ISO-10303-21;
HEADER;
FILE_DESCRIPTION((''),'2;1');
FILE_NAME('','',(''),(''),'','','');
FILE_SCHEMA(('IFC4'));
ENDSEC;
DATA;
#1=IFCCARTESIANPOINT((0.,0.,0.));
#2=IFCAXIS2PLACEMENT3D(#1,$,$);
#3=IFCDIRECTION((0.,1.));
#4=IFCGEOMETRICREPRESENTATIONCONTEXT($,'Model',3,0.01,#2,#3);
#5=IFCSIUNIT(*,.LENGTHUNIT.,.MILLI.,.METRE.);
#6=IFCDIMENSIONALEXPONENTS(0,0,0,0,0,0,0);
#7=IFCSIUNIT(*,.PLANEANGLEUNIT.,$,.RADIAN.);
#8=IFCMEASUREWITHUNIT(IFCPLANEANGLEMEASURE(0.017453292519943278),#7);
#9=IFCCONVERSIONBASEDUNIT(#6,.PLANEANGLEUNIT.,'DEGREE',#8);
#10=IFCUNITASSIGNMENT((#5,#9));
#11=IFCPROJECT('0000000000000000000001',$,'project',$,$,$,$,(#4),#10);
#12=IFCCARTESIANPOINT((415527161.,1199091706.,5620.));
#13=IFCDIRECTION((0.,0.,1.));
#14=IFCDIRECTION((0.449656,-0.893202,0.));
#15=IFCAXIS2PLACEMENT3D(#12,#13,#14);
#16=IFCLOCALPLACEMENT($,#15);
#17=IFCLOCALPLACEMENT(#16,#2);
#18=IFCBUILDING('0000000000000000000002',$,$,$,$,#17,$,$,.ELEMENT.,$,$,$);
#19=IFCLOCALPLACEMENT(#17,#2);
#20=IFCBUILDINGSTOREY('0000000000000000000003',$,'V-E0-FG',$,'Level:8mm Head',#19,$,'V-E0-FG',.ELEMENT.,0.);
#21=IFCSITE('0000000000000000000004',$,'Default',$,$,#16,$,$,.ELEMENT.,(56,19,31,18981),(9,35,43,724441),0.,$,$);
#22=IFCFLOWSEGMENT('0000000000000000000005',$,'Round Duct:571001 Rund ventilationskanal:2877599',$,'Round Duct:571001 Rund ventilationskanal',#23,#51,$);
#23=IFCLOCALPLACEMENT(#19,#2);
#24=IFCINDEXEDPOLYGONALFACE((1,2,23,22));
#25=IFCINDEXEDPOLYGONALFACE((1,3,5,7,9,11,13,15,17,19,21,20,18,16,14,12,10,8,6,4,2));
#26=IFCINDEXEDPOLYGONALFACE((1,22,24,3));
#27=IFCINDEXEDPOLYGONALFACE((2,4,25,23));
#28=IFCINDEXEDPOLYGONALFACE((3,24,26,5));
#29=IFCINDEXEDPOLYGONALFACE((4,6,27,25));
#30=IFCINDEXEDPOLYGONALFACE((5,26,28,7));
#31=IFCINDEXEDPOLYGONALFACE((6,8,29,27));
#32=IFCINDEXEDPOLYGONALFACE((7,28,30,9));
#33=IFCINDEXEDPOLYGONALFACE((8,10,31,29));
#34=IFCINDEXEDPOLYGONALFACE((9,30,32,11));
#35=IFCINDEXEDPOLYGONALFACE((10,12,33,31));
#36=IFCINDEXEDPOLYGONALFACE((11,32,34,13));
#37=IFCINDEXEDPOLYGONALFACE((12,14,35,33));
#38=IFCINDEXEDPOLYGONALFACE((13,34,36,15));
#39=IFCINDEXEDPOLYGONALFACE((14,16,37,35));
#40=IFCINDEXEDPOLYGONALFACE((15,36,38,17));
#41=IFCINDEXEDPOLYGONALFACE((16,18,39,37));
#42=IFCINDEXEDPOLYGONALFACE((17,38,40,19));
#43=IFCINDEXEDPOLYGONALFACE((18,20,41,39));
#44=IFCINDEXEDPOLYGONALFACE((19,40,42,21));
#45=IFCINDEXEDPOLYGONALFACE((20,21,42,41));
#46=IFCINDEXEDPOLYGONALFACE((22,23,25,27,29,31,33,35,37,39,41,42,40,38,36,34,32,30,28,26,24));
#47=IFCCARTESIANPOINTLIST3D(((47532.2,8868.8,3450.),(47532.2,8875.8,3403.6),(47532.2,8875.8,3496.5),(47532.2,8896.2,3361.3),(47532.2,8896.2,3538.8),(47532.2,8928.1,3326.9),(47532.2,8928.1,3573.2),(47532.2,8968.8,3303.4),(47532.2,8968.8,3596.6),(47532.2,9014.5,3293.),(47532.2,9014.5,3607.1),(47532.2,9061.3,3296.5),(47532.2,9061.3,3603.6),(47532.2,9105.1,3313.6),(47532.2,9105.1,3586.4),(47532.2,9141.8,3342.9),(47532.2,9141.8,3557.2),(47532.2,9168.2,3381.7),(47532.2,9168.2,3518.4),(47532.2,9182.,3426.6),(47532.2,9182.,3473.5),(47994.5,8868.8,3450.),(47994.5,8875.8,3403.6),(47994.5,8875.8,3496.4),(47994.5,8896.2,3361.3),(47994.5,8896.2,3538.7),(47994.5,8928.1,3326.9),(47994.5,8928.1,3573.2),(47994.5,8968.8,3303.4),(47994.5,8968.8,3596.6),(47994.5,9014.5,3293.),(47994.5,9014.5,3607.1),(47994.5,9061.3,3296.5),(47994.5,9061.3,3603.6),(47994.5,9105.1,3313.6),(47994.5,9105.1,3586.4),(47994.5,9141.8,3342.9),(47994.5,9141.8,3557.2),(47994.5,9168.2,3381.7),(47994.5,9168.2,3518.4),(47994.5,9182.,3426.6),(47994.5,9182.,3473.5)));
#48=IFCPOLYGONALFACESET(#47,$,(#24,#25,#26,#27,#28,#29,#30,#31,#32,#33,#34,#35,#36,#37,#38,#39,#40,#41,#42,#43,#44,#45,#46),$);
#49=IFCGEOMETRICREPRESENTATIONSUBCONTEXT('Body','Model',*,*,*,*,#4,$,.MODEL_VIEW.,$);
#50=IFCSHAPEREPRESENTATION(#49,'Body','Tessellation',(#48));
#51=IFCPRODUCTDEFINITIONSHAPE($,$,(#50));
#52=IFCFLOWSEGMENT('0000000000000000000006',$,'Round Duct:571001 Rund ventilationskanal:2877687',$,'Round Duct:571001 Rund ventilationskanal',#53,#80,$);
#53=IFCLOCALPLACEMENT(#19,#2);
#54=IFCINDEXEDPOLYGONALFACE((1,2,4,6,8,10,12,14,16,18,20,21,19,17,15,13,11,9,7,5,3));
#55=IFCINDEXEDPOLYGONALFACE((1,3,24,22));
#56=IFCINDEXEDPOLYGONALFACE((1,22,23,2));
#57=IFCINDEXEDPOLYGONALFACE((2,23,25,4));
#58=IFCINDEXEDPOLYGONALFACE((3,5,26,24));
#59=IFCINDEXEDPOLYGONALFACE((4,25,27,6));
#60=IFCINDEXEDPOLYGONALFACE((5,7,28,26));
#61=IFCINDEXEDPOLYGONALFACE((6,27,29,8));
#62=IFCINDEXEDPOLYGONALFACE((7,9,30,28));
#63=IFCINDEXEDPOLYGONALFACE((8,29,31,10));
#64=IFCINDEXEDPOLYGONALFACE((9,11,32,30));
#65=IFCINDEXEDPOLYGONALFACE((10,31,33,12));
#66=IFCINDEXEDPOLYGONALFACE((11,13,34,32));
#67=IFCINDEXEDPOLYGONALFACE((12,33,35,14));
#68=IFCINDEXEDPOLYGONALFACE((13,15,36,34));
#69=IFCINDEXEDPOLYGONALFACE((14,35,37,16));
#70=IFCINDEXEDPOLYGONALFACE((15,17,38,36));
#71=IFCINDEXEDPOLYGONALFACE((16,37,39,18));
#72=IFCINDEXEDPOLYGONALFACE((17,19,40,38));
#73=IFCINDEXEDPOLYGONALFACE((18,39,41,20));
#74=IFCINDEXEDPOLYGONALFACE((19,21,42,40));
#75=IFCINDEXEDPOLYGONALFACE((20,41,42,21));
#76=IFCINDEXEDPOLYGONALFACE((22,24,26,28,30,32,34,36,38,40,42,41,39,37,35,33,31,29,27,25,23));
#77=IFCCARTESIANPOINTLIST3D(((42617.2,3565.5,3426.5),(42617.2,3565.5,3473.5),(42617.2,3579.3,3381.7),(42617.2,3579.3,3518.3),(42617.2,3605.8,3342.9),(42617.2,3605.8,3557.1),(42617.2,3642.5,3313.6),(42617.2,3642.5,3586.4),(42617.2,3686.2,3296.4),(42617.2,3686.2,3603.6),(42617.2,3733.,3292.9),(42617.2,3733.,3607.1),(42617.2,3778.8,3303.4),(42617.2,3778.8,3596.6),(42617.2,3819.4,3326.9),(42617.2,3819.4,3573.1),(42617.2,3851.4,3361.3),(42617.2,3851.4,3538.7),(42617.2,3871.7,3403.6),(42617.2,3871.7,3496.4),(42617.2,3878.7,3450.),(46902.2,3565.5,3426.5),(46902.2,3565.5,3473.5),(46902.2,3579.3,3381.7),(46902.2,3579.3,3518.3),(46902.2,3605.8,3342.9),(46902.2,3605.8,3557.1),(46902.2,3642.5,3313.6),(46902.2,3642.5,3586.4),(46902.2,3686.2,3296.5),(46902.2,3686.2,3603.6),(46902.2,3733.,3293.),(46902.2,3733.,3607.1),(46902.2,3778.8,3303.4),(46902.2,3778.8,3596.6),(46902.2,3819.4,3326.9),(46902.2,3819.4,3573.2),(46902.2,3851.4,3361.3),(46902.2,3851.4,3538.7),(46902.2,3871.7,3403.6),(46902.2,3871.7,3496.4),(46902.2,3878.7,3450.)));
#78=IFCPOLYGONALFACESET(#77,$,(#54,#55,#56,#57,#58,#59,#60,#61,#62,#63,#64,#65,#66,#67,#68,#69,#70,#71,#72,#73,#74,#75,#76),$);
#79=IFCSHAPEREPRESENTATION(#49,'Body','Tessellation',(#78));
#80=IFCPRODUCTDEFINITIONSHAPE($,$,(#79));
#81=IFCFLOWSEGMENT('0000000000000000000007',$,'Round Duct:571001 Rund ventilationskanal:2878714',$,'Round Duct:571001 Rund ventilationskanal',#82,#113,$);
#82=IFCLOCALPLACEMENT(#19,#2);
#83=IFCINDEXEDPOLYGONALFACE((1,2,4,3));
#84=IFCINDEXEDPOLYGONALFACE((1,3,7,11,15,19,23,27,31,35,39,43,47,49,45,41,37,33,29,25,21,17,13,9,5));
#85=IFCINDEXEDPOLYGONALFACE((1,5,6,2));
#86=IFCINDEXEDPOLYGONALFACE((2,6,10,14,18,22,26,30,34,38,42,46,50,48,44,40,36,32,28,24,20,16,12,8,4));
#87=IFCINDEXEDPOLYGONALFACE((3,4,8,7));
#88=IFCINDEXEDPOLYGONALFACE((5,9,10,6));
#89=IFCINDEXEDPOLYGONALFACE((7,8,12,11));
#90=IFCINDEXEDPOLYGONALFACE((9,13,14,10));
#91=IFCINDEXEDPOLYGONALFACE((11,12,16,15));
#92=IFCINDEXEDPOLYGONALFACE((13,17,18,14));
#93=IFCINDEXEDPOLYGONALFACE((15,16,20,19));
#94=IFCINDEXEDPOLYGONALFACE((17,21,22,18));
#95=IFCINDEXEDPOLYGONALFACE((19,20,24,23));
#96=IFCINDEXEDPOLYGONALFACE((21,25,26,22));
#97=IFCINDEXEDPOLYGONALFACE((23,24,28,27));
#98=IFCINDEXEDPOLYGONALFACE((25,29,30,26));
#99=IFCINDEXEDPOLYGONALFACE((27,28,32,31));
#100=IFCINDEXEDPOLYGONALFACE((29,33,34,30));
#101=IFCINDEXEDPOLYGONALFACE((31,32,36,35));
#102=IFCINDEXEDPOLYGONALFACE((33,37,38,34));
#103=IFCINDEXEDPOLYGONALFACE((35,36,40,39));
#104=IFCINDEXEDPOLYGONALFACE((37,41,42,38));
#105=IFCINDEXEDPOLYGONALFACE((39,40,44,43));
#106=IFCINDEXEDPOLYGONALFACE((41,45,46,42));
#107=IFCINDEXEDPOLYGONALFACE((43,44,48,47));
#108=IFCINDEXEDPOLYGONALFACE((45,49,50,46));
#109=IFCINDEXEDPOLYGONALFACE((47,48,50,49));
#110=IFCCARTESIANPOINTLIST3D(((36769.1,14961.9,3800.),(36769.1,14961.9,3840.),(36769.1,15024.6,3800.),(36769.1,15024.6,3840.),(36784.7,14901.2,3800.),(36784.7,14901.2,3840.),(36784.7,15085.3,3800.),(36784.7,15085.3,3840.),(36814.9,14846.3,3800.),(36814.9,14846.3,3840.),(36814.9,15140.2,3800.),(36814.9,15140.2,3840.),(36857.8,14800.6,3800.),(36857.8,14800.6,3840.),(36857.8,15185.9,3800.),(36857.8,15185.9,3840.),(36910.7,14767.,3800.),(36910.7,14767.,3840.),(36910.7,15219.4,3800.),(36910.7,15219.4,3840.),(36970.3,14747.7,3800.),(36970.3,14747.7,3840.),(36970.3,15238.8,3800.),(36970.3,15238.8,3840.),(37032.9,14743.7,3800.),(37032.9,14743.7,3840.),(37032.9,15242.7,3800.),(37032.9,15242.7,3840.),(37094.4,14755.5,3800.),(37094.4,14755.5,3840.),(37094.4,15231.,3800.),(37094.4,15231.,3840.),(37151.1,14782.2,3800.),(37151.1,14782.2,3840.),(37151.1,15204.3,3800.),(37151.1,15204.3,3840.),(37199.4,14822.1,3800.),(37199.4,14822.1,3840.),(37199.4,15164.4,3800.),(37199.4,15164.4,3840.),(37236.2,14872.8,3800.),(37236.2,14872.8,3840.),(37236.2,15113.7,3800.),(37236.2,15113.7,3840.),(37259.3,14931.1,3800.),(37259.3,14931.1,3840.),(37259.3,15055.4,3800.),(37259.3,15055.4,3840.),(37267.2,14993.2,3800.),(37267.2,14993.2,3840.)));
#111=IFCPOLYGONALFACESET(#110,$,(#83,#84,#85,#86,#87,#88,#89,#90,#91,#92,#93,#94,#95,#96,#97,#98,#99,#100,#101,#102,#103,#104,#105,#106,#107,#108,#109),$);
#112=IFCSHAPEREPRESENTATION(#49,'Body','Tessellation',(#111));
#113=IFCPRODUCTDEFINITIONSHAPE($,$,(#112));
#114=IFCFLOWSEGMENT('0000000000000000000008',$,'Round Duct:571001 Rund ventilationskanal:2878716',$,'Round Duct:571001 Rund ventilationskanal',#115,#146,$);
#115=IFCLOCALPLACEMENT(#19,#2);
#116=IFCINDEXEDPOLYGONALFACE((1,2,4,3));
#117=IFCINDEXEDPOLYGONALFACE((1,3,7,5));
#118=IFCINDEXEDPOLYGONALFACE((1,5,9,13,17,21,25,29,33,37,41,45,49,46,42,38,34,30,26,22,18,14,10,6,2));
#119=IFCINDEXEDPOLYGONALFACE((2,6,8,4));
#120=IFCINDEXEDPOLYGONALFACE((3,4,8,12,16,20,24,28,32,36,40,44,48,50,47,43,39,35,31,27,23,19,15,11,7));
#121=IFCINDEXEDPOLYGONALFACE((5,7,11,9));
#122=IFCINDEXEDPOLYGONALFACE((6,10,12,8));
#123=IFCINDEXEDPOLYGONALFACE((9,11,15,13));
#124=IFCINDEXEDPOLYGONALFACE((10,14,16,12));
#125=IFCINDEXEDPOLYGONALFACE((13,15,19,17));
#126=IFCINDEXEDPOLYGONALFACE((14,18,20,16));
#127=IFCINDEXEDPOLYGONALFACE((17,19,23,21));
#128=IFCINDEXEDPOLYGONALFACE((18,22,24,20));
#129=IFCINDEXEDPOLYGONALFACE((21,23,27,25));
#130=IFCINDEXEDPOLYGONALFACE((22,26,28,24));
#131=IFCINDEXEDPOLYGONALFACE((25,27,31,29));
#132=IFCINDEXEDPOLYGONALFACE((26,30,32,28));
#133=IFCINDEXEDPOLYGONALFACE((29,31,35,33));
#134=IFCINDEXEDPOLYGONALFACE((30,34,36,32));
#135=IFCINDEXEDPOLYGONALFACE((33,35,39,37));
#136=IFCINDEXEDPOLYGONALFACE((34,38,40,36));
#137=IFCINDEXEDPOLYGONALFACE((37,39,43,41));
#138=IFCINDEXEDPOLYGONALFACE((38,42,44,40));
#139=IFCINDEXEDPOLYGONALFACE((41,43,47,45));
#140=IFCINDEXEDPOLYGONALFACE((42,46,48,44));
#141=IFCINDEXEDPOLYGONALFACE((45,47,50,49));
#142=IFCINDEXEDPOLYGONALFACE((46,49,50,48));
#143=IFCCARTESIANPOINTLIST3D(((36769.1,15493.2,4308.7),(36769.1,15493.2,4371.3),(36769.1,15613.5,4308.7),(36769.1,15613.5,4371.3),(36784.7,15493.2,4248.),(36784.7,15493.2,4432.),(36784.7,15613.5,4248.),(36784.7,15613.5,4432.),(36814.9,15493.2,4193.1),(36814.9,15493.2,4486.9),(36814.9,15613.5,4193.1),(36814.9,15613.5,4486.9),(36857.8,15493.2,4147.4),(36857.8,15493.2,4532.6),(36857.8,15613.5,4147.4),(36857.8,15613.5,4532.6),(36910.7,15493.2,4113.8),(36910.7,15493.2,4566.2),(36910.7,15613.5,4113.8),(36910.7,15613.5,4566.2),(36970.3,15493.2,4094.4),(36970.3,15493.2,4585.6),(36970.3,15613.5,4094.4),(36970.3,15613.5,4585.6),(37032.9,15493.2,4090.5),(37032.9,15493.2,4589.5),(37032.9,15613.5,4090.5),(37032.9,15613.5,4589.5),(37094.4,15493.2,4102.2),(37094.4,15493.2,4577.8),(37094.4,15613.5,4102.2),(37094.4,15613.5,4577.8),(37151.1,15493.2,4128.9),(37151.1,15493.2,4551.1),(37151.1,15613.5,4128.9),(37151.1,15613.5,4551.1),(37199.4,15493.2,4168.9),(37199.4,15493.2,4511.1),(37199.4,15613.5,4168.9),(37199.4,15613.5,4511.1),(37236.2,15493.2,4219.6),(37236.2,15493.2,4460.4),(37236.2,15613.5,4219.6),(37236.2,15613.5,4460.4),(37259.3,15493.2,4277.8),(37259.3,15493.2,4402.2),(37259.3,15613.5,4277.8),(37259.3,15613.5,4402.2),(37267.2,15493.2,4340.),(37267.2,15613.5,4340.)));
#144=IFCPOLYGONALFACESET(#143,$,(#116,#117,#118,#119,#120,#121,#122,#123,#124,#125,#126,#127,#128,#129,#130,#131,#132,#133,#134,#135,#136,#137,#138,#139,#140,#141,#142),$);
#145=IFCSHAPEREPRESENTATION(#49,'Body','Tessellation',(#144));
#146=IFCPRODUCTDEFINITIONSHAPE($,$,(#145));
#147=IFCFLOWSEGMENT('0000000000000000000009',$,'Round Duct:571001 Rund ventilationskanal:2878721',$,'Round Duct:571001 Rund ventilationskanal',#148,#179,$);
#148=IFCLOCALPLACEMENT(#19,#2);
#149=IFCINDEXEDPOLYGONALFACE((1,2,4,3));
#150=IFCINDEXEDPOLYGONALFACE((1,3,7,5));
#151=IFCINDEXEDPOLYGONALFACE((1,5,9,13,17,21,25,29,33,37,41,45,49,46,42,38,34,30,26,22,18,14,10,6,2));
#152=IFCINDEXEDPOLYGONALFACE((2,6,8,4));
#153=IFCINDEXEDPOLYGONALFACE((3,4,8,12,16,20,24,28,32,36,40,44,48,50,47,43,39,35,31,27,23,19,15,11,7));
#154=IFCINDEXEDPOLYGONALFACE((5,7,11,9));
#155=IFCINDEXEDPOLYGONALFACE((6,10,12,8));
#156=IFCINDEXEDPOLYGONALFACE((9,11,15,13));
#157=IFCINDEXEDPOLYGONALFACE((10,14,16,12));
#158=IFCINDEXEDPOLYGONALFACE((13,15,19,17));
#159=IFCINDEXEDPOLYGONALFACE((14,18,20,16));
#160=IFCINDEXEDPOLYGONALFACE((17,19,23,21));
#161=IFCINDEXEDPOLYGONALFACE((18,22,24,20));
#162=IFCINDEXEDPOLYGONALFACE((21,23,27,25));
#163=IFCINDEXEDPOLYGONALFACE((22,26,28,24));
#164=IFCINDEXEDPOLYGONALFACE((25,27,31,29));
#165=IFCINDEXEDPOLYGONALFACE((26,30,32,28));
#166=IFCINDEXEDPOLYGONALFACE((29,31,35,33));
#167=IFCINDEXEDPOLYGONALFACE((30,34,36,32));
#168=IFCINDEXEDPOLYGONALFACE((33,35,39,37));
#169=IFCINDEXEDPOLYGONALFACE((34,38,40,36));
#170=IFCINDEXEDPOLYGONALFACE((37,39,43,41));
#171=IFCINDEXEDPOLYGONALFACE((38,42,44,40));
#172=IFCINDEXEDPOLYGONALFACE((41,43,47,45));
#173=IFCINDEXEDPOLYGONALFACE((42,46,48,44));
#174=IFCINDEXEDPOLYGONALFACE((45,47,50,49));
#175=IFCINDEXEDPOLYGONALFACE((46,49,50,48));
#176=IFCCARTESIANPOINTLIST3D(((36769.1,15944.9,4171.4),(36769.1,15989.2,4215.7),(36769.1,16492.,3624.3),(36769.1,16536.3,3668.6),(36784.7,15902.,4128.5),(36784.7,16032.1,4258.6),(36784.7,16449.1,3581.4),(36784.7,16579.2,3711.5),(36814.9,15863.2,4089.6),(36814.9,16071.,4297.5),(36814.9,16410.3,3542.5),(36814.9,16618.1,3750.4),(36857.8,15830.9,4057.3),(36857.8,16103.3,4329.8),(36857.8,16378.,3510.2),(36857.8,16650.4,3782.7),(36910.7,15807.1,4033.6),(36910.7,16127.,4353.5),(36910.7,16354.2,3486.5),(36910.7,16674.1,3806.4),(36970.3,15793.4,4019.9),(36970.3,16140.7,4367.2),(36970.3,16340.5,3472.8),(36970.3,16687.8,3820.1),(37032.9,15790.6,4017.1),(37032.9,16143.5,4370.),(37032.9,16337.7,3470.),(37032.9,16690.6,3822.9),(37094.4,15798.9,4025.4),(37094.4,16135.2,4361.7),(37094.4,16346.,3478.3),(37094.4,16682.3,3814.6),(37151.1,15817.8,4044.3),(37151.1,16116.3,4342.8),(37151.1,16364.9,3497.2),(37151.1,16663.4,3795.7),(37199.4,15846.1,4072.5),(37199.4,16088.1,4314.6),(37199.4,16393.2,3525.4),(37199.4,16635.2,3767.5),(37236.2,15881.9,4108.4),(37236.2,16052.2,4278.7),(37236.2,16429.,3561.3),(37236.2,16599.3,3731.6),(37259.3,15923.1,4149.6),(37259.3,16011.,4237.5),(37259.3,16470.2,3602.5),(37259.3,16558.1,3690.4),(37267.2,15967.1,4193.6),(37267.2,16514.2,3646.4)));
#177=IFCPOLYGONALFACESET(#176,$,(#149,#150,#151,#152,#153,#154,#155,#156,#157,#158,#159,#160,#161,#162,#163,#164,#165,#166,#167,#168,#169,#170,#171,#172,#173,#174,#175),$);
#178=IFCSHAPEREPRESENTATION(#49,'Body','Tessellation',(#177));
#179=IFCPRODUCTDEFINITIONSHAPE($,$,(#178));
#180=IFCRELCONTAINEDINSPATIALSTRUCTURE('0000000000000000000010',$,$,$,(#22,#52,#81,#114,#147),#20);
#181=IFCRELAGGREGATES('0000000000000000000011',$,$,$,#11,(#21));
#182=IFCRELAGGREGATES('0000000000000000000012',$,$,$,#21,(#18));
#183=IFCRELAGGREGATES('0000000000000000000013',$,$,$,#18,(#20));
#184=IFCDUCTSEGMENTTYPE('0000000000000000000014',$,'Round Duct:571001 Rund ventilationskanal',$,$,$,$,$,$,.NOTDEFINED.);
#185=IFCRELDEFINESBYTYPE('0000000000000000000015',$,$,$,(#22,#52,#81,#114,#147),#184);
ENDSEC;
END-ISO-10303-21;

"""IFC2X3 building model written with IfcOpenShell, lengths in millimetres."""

from ifc_helpers import new_model, entity, si_unit, converted_unit, direction, frame, frame_2d, origin, origin_2d_with_axis, place, context, subcontext, project, spatial, circle, extrude, type_object, element, save


model = new_model("IFC2X3")

# Units and contexts
model_context = context("Model", 3, precision=0.01, world=origin(), true_north=direction((0.0, 1.0)))
body_context = subcontext(model_context, "Body", "Model", "MODEL_VIEW")
ifc_project = project(units=[si_unit("LENGTHUNIT", "METRE", prefix="MILLI"), converted_unit("PLANEANGLEUNIT", "DEGREE", entity("IfcPlaneAngleMeasure", 0.017453292519943278), si_unit("PLANEANGLEUNIT", "RADIAN"), dimensions=[0, 0, 0, 0, 0, 0, 0])], contexts=[model_context])

# Site, building, storey
site_placement = place(None, frame((415527161.0, 1199091706.0, 5620.0), z_axis=(0.0, 0.0, 1.0), x_axis=(0.449656, -0.893202, 0.0)))
site = spatial("IfcSite", under=ifc_project, at=site_placement, Name="Default", CompositionType="ELEMENT", RefLatitude=(56, 19, 31, 18981), RefLongitude=(9, 35, 43, 724441), RefElevation=0.0)
building_placement = place(site_placement, origin())
building = spatial("IfcBuilding", under=site, at=building_placement, CompositionType="ELEMENT")
storey_placement = place(building_placement, origin())
storey = spatial("IfcBuildingStorey", under=building, at=storey_placement, Name="V-E0-FG", ObjectType="Level:8mm Head", LongName="V-E0-FG", CompositionType="ELEMENT", Elevation=0.0)

# Flow segments
duct_segment_type = type_object("IfcDuctSegmentType", Name="Round Duct:571001 Rund ventilationskanal", PredefinedType="NOTDEFINED")
flow_segment_1_placement = place(storey_placement, origin())
element("IfcFlowSegment", 1, at=flow_segment_1_placement, inside=storey, type_object=duct_segment_type, Name="Round Duct:571001 Rund ventilationskanal:2877599", ObjectType="Round Duct:571001 Rund ventilationskanal", context=body_context, shape_type="SweptSolid", body=[
    extrude(circle(Radius=157.5, at=frame_2d((0.0, 0.0), x_axis=(1.0, 0.0))), frame((47532.2, 9026.3, 3450.0), z_axis=(1.0, -0.000001, -0.000007), x_axis=(-0.000001, -1.0, 0.0)), (0.0, 0.0, 1.0), 462.3),
])
flow_segment_2_placement = place(storey_placement, origin())
element("IfcFlowSegment", 2, at=flow_segment_2_placement, inside=storey, type_object=duct_segment_type, Name="Round Duct:571001 Rund ventilationskanal:2877687", ObjectType="Round Duct:571001 Rund ventilationskanal", context=body_context, shape_type="SweptSolid", body=[
    extrude(circle(Radius=157.5, at=frame_2d((0.0, 0.0), x_axis=(1.0, 0.0))), frame((42617.2, 3721.2, 3450.0), z_axis=(1.0, 0.0, 0.000003), x_axis=(0.0, 1.0, 0.0)), (0.0, 0.0, 1.0), 4285.0),
])
flow_segment_3_placement = place(storey_placement, origin())
element("IfcFlowSegment", 3, at=flow_segment_3_placement, inside=storey, type_object=duct_segment_type, Name="Round Duct:571001 Rund ventilationskanal:2878714", ObjectType="Round Duct:571001 Rund ventilationskanal", context=body_context, shape_type="SweptSolid", body=[
    extrude(circle(Radius=250.0, at=frame_2d((0.0, 0.0), x_axis=(1.0, 0.0))), frame((37017.2, 14993.2, 3800.0)), (0.0, 0.0, 1.0), 40.0),
])
flow_segment_4_placement = place(storey_placement, origin())
element("IfcFlowSegment", 4, at=flow_segment_4_placement, inside=storey, type_object=duct_segment_type, Name="Round Duct:571001 Rund ventilationskanal:2878716", ObjectType="Round Duct:571001 Rund ventilationskanal", context=body_context, shape_type="SweptSolid", body=[
    extrude(circle(Radius=250.0, at=origin_2d_with_axis()), frame((37017.2, 15493.2, 4340.0), z_axis=(0.0, 1.0, 0.0), x_axis=(1.0, 0.0, 0.0)), (0.0, 0.0, 1.0), 120.3),
])
flow_segment_5_placement = place(storey_placement, origin())
element("IfcFlowSegment", 5, at=flow_segment_5_placement, inside=storey, type_object=duct_segment_type, Name="Round Duct:571001 Rund ventilationskanal:2878721", ObjectType="Round Duct:571001 Rund ventilationskanal", context=body_context, shape_type="SweptSolid", body=[
    extrude(circle(Radius=250.0, at=origin_2d_with_axis()), frame((37017.2, 15967.1, 4193.6), z_axis=(0.0, 0.707107, -0.707107), x_axis=(1.0, 0.0, 0.0)), (0.0, 0.0, 1.0), 773.7),
])

save(model, "model.ifc")
